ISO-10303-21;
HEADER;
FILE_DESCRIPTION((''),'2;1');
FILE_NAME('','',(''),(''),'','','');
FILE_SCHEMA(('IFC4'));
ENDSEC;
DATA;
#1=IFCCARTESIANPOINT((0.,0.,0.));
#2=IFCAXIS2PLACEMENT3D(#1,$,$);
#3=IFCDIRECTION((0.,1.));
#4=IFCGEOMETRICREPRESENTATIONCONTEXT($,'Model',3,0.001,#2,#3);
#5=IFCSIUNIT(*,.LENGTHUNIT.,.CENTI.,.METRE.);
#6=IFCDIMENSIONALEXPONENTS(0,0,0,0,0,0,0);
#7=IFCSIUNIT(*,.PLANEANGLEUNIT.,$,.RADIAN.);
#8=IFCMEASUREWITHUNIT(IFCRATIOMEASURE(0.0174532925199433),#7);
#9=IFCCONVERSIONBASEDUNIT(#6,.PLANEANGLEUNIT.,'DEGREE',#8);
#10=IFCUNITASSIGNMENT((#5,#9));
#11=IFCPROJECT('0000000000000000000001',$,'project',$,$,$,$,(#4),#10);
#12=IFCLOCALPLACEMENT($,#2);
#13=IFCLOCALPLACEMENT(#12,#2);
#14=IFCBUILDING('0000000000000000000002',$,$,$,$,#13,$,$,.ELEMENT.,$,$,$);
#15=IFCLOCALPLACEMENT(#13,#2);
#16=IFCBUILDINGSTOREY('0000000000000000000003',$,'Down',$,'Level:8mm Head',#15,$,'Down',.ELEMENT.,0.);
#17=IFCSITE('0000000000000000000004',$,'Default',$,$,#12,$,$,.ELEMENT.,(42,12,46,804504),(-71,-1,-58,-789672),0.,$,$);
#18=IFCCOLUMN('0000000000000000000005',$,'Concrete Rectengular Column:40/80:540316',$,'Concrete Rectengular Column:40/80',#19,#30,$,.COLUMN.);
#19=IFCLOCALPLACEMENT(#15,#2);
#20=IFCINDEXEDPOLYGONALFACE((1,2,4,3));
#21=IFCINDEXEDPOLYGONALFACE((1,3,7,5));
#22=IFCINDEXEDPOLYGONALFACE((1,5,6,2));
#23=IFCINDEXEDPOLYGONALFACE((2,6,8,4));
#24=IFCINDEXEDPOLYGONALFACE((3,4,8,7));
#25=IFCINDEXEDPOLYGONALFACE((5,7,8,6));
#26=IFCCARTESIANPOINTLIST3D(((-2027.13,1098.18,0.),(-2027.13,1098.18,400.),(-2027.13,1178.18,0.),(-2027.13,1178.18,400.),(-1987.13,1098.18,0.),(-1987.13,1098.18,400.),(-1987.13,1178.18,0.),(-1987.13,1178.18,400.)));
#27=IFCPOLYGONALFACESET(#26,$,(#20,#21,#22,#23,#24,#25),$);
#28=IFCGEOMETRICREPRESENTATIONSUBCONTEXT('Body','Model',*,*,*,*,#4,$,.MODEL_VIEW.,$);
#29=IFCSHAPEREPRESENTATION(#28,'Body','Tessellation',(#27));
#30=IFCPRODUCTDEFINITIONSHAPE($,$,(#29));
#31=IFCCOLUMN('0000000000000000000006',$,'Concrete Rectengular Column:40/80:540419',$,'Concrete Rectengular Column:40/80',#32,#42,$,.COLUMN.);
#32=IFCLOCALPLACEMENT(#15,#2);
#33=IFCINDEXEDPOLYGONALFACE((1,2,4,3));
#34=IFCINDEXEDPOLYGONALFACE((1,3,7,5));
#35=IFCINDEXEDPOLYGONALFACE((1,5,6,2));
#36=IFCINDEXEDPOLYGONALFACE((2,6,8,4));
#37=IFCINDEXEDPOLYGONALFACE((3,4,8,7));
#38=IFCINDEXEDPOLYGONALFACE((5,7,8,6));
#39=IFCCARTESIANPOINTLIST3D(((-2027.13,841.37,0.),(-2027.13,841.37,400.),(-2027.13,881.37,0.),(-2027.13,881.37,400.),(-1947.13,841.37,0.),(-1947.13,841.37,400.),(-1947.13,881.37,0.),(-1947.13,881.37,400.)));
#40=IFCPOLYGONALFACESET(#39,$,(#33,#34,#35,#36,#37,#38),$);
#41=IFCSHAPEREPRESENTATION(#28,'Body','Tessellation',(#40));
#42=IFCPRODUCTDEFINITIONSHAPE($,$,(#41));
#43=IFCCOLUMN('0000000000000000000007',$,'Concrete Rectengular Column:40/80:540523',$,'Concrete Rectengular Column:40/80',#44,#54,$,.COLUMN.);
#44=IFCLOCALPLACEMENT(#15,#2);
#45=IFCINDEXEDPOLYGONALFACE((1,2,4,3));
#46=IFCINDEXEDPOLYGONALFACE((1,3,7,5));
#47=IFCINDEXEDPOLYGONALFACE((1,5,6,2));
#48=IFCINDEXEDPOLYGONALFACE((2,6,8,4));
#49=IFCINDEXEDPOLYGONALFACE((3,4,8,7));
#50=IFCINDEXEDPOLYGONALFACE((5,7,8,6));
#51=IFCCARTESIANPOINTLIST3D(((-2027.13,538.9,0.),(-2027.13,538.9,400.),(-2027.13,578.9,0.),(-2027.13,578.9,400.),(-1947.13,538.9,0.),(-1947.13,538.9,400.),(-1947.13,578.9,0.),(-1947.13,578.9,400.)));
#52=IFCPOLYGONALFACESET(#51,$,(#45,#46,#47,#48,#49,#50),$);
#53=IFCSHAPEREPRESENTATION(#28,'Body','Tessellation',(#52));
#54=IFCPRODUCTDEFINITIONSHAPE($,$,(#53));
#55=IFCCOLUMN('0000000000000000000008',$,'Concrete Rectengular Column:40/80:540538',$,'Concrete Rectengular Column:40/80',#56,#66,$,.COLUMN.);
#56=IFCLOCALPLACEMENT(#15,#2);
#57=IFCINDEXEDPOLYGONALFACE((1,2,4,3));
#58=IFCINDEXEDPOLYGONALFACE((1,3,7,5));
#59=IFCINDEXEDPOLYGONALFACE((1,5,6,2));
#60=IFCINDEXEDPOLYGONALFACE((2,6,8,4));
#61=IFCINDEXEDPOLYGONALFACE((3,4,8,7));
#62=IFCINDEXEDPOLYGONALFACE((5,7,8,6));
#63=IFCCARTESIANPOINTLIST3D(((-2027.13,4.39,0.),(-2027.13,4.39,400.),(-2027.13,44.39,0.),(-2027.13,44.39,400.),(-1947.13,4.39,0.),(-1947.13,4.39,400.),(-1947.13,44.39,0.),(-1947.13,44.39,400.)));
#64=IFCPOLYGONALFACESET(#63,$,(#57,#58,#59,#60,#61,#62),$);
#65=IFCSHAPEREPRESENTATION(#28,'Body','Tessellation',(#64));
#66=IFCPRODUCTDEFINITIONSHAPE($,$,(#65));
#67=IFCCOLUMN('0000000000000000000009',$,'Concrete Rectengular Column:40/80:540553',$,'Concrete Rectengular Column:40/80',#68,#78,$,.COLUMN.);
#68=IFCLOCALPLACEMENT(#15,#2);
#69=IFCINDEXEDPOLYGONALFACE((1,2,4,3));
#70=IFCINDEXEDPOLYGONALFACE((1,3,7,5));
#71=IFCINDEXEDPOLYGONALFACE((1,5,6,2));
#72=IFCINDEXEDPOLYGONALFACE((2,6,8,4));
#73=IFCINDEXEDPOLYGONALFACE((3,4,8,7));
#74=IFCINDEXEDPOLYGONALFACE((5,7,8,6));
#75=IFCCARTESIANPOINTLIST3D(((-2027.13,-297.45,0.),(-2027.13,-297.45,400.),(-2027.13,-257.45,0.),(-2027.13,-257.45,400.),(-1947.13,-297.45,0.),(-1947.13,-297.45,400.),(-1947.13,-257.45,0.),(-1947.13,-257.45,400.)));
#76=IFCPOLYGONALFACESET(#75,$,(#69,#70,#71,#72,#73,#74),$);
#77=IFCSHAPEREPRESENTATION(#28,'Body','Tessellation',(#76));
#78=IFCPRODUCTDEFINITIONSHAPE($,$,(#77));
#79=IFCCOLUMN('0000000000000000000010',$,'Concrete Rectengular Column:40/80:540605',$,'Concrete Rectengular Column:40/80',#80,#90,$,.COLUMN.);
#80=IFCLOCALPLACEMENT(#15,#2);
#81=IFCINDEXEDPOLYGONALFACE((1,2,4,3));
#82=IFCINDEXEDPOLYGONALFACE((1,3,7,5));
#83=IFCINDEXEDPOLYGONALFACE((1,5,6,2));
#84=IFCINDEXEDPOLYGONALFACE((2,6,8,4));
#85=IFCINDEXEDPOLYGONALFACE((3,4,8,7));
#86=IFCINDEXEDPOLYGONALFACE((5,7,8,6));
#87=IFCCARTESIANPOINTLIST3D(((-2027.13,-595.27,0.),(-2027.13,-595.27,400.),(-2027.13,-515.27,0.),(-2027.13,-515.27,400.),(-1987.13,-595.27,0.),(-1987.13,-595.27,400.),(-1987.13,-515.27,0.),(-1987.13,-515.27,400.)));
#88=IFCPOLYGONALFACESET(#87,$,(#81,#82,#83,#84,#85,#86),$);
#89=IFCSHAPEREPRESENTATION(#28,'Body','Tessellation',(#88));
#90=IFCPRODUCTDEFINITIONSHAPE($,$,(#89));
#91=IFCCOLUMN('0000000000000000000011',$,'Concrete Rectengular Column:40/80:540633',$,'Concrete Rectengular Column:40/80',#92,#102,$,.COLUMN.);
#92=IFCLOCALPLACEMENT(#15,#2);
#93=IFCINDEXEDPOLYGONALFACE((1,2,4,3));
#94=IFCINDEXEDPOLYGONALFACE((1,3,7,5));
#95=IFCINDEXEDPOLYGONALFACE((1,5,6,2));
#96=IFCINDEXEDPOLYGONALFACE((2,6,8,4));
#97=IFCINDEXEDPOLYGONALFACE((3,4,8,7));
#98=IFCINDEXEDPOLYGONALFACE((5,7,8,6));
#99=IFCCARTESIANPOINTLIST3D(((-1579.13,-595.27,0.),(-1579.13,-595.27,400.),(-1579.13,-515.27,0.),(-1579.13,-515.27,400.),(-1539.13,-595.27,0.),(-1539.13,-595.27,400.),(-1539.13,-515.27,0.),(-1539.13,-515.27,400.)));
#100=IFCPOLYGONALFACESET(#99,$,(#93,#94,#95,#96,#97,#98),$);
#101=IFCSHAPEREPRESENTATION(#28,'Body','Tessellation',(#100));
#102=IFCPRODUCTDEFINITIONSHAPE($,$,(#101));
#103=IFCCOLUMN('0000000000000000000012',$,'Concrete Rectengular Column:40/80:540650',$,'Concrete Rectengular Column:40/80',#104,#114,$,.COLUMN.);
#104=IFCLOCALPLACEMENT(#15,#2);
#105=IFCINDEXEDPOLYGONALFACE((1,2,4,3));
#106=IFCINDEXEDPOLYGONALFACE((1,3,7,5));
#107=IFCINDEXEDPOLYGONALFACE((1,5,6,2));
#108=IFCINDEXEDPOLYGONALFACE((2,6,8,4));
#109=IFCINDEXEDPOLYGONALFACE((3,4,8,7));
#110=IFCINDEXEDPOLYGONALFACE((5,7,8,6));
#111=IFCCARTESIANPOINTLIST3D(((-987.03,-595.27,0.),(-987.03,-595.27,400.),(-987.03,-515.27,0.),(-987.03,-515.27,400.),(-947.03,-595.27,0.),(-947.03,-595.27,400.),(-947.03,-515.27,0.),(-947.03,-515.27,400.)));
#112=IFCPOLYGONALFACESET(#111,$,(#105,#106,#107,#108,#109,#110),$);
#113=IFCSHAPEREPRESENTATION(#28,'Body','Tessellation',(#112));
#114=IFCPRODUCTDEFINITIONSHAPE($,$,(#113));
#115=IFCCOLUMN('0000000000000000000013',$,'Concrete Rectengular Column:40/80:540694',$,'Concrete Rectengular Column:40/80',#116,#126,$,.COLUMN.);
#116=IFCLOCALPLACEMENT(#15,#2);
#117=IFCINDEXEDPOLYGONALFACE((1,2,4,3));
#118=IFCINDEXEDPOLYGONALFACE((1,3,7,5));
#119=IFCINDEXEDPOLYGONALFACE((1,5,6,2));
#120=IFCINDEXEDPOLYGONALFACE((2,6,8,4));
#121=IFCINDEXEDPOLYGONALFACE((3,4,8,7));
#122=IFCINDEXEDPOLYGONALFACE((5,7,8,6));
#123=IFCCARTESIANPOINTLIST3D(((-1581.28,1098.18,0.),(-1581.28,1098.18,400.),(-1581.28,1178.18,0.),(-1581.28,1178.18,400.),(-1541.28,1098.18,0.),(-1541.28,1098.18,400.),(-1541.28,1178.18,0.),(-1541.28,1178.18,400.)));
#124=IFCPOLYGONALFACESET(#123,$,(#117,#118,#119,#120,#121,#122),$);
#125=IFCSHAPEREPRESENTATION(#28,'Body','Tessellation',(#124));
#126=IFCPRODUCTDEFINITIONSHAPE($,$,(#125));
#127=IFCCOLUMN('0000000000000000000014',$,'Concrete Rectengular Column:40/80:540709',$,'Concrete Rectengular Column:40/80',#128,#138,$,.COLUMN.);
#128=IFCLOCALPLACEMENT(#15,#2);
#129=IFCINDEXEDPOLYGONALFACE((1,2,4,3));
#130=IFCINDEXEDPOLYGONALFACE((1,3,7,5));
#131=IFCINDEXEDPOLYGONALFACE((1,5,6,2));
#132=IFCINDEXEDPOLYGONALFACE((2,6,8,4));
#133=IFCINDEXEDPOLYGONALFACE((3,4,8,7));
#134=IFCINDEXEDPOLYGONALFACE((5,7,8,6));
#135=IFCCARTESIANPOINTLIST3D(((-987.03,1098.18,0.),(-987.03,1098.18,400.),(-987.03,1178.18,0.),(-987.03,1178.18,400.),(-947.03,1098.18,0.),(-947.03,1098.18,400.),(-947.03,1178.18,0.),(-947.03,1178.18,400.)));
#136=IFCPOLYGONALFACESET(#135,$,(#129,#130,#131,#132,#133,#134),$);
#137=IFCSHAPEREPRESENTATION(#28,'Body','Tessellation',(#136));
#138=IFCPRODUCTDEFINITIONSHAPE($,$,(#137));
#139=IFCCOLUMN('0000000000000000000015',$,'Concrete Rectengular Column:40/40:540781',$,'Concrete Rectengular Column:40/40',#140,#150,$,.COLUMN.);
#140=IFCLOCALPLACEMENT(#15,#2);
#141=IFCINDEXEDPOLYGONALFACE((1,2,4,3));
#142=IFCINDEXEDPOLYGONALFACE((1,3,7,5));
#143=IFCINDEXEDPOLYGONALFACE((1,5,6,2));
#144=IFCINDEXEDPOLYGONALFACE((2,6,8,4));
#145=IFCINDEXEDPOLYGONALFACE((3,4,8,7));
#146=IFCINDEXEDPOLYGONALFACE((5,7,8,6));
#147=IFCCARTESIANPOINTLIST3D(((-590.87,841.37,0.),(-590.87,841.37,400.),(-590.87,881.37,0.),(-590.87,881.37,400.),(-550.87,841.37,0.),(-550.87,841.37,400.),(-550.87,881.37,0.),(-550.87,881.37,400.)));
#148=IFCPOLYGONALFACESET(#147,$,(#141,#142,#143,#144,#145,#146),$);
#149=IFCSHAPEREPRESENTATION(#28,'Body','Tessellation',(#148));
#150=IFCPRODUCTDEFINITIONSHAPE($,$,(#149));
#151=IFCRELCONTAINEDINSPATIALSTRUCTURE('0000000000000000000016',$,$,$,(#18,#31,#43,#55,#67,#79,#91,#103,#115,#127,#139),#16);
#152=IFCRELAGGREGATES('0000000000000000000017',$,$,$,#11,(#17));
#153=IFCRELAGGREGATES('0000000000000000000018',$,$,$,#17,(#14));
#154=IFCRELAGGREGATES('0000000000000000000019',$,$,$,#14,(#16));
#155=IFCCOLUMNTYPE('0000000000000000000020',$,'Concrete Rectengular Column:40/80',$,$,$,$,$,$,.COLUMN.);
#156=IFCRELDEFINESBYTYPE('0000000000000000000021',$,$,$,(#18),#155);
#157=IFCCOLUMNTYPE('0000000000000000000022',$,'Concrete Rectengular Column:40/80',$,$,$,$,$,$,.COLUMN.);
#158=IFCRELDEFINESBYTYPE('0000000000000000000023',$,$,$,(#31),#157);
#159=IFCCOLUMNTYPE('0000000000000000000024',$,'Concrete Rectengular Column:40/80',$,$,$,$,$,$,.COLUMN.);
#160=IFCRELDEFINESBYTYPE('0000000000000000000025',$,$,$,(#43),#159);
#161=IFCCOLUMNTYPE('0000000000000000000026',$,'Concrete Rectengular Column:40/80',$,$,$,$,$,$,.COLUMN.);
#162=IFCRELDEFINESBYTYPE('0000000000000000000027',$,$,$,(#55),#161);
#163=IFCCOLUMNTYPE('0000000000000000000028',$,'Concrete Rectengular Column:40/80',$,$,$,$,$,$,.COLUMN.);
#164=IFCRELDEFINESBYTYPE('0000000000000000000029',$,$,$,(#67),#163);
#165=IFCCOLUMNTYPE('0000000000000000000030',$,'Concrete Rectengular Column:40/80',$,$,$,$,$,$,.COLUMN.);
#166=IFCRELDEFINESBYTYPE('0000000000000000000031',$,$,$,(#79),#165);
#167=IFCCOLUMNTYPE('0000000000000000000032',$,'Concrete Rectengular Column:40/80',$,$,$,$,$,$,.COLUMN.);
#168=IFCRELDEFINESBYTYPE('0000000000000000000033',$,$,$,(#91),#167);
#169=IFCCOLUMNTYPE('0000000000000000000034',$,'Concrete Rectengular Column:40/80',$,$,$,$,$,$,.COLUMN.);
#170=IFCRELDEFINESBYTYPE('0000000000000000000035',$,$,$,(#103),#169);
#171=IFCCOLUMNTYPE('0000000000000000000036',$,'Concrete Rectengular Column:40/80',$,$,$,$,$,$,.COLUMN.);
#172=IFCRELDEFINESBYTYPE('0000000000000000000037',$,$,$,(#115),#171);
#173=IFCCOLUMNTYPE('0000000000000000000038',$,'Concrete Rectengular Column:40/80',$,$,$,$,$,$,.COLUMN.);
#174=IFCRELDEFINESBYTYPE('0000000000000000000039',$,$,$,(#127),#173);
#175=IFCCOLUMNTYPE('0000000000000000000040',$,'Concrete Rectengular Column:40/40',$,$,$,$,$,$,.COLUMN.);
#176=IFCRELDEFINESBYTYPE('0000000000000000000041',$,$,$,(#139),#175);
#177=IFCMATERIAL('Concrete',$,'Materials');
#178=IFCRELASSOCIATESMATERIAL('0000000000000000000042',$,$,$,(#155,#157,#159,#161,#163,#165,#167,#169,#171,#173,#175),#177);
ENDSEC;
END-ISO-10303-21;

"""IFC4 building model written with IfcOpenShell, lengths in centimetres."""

from ifc_helpers import new_model, entity, si_unit, converted_unit, direction, frame, origin, place, context, subcontext, project, spatial, indexed_curve, outline, extrude, source, transform, mapped, material, type_object, type_shapes, element, save


model = new_model("IFC4")

# Units and contexts
model_context = context("Model", 3, precision=0.001, world=origin(), true_north=direction((0.0, 1.0)))
body_context = subcontext(model_context, "Body", "Model", "MODEL_VIEW")
ifc_project = project(units=[si_unit("LENGTHUNIT", "METRE", prefix="CENTI"), converted_unit("PLANEANGLEUNIT", "DEGREE", entity("IfcRatioMeasure", 0.0174532925199433), si_unit("PLANEANGLEUNIT", "RADIAN"), dimensions=[0, 0, 0, 0, 0, 0, 0])], contexts=[model_context])

# Site, building, storey
site_placement = place(None, origin())
site = spatial("IfcSite", under=ifc_project, at=site_placement, Name="Default", CompositionType="ELEMENT", RefLatitude=(42, 12, 46, 804504), RefLongitude=(-71, -1, -58, -789672), RefElevation=0.0)
building_placement = place(site_placement, origin())
building = spatial("IfcBuilding", under=site, at=building_placement, CompositionType="ELEMENT")
storey_placement = place(building_placement, origin())
storey = spatial("IfcBuildingStorey", under=building, at=storey_placement, Name="Down", ObjectType="Level:8mm Head", LongName="Down", CompositionType="ELEMENT", Elevation=0.0)

# Columns
ifc_material = material(Name="Concrete", Category="Materials")
column_type_1 = type_object("IfcColumnType", Name="Concrete Rectengular Column:40/80", PredefinedType="COLUMN", material=ifc_material)
shared_shape_1 = source(origin(), body_context, "Body", "SweptSolid", [
    extrude(outline(indexed_curve([(-40.0, -20.0), (40.0, -20.0), (40.0, 20.0), (-40.0, 20.0), (-40.0, -20.0)], self_intersect=False)), frame((-2007.13, 1138.18, 0.0), z_axis=(0.0, 0.0, 1.0), x_axis=(0.0, -1.0, 0.0)), (0.0, 0.0, 1.0), 400.0),
])
type_shapes(column_type_1, [shared_shape_1])
column_1_placement = place(storey_placement, origin())
element("IfcColumn", 1, at=column_1_placement, inside=storey, type_object=column_type_1, Name="Concrete Rectengular Column:40/80:540316", ObjectType="Concrete Rectengular Column:40/80", PredefinedType="COLUMN", context=body_context, shape_type="MappedRepresentation", body=[
    mapped(shared_shape_1, transform((0.0, 0.0, 0.0), scale=1.0)),
])
column_type_2 = type_object("IfcColumnType", Name="Concrete Rectengular Column:40/80", PredefinedType="COLUMN", material=ifc_material)
shared_shape_2 = source(origin(), body_context, "Body", "SweptSolid", [
    extrude(outline(indexed_curve([(-20.0, -40.0), (20.0, -40.0), (20.0, 40.0), (-20.0, 40.0), (-20.0, -40.0)], self_intersect=False)), frame((-1987.13, 861.37, 0.0), z_axis=(0.0, 0.0, 1.0), x_axis=(0.0, -1.0, 0.0)), (0.0, 0.0, 1.0), 400.0),
])
type_shapes(column_type_2, [shared_shape_2])
column_2_placement = place(storey_placement, origin())
element("IfcColumn", 2, at=column_2_placement, inside=storey, type_object=column_type_2, Name="Concrete Rectengular Column:40/80:540419", ObjectType="Concrete Rectengular Column:40/80", PredefinedType="COLUMN", context=body_context, shape_type="MappedRepresentation", body=[
    mapped(shared_shape_2, transform((0.0, 0.0, 0.0), scale=1.0)),
])
column_type_3 = type_object("IfcColumnType", Name="Concrete Rectengular Column:40/80", PredefinedType="COLUMN", material=ifc_material)
shared_shape_3 = source(origin(), body_context, "Body", "SweptSolid", [
    extrude(outline(indexed_curve([(-20.0, -40.0), (20.0, -40.0), (20.0, 40.0), (-20.0, 40.0), (-20.0, -40.0)], self_intersect=False)), frame((-1987.13, 558.9, 0.0), z_axis=(0.0, 0.0, 1.0), x_axis=(0.0, -1.0, 0.0)), (0.0, 0.0, 1.0), 400.0),
])
type_shapes(column_type_3, [shared_shape_3])
column_3_placement = place(storey_placement, origin())
element("IfcColumn", 3, at=column_3_placement, inside=storey, type_object=column_type_3, Name="Concrete Rectengular Column:40/80:540523", ObjectType="Concrete Rectengular Column:40/80", PredefinedType="COLUMN", context=body_context, shape_type="MappedRepresentation", body=[
    mapped(shared_shape_3, transform((0.0, 0.0, 0.0), scale=1.0)),
])
column_type_4 = type_object("IfcColumnType", Name="Concrete Rectengular Column:40/80", PredefinedType="COLUMN", material=ifc_material)
shared_shape_4 = source(origin(), body_context, "Body", "SweptSolid", [
    extrude(outline(indexed_curve([(-20.0, -40.0), (20.0, -40.0), (20.0, 40.0), (-20.0, 40.0), (-20.0, -40.0)], self_intersect=False)), frame((-1987.13, 24.39, 0.0), z_axis=(0.0, 0.0, 1.0), x_axis=(0.0, -1.0, 0.0)), (0.0, 0.0, 1.0), 400.0),
])
type_shapes(column_type_4, [shared_shape_4])
column_4_placement = place(storey_placement, origin())
element("IfcColumn", 4, at=column_4_placement, inside=storey, type_object=column_type_4, Name="Concrete Rectengular Column:40/80:540538", ObjectType="Concrete Rectengular Column:40/80", PredefinedType="COLUMN", context=body_context, shape_type="MappedRepresentation", body=[
    mapped(shared_shape_4, transform((0.0, 0.0, 0.0), scale=1.0)),
])
column_type_5 = type_object("IfcColumnType", Name="Concrete Rectengular Column:40/80", PredefinedType="COLUMN", material=ifc_material)
shared_shape_5 = source(origin(), body_context, "Body", "SweptSolid", [
    extrude(outline(indexed_curve([(-20.0, -40.0), (20.0, -40.0), (20.0, 40.0), (-20.0, 40.0), (-20.0, -40.0)], self_intersect=False)), frame((-1987.13, -277.45, 0.0), z_axis=(0.0, 0.0, 1.0), x_axis=(0.0, -1.0, 0.0)), (0.0, 0.0, 1.0), 400.0),
])
type_shapes(column_type_5, [shared_shape_5])
column_5_placement = place(storey_placement, origin())
element("IfcColumn", 5, at=column_5_placement, inside=storey, type_object=column_type_5, Name="Concrete Rectengular Column:40/80:540553", ObjectType="Concrete Rectengular Column:40/80", PredefinedType="COLUMN", context=body_context, shape_type="MappedRepresentation", body=[
    mapped(shared_shape_5, transform((0.0, 0.0, 0.0), scale=1.0)),
])
column_type_6 = type_object("IfcColumnType", Name="Concrete Rectengular Column:40/80", PredefinedType="COLUMN", material=ifc_material)
shared_shape_6 = source(origin(), body_context, "Body", "SweptSolid", [
    extrude(outline(indexed_curve([(-40.0, -20.0), (40.0, -20.0), (40.0, 20.0), (-40.0, 20.0), (-40.0, -20.0)], self_intersect=False)), frame((-2007.13, -555.27, 0.0), z_axis=(0.0, 0.0, 1.0), x_axis=(0.0, -1.0, 0.0)), (0.0, 0.0, 1.0), 400.0),
])
type_shapes(column_type_6, [shared_shape_6])
column_6_placement = place(storey_placement, origin())
element("IfcColumn", 6, at=column_6_placement, inside=storey, type_object=column_type_6, Name="Concrete Rectengular Column:40/80:540605", ObjectType="Concrete Rectengular Column:40/80", PredefinedType="COLUMN", context=body_context, shape_type="MappedRepresentation", body=[
    mapped(shared_shape_6, transform((0.0, 0.0, 0.0), scale=1.0)),
])
column_type_7 = type_object("IfcColumnType", Name="Concrete Rectengular Column:40/80", PredefinedType="COLUMN", material=ifc_material)
shared_shape_7 = source(origin(), body_context, "Body", "SweptSolid", [
    extrude(outline(indexed_curve([(-40.0, -20.0), (40.0, -20.0), (40.0, 20.0), (-40.0, 20.0), (-40.0, -20.0)], self_intersect=False)), frame((-1559.13, -555.27, 0.0), z_axis=(0.0, 0.0, 1.0), x_axis=(0.0, -1.0, 0.0)), (0.0, 0.0, 1.0), 400.0),
])
type_shapes(column_type_7, [shared_shape_7])
column_7_placement = place(storey_placement, origin())
element("IfcColumn", 7, at=column_7_placement, inside=storey, type_object=column_type_7, Name="Concrete Rectengular Column:40/80:540633", ObjectType="Concrete Rectengular Column:40/80", PredefinedType="COLUMN", context=body_context, shape_type="MappedRepresentation", body=[
    mapped(shared_shape_7, transform((0.0, 0.0, 0.0), scale=1.0)),
])
column_type_8 = type_object("IfcColumnType", Name="Concrete Rectengular Column:40/80", PredefinedType="COLUMN", material=ifc_material)
shared_shape_8 = source(origin(), body_context, "Body", "SweptSolid", [
    extrude(outline(indexed_curve([(-40.0, -20.0), (40.0, -20.0), (40.0, 20.0), (-40.0, 20.0), (-40.0, -20.0)], self_intersect=False)), frame((-967.03, -555.27, 0.0), z_axis=(0.0, 0.0, 1.0), x_axis=(0.0, -1.0, 0.0)), (0.0, 0.0, 1.0), 400.0),
])
type_shapes(column_type_8, [shared_shape_8])
column_8_placement = place(storey_placement, origin())
element("IfcColumn", 8, at=column_8_placement, inside=storey, type_object=column_type_8, Name="Concrete Rectengular Column:40/80:540650", ObjectType="Concrete Rectengular Column:40/80", PredefinedType="COLUMN", context=body_context, shape_type="MappedRepresentation", body=[
    mapped(shared_shape_8, transform((0.0, 0.0, 0.0), scale=1.0)),
])
column_type_9 = type_object("IfcColumnType", Name="Concrete Rectengular Column:40/80", PredefinedType="COLUMN", material=ifc_material)
shared_shape_9 = source(origin(), body_context, "Body", "SweptSolid", [
    extrude(outline(indexed_curve([(-40.0, -20.0), (40.0, -20.0), (40.0, 20.0), (-40.0, 20.0), (-40.0, -20.0)], self_intersect=False)), frame((-1561.28, 1138.18, 0.0), z_axis=(0.0, 0.0, 1.0), x_axis=(0.0, -1.0, 0.0)), (0.0, 0.0, 1.0), 400.0),
])
type_shapes(column_type_9, [shared_shape_9])
column_9_placement = place(storey_placement, origin())
element("IfcColumn", 9, at=column_9_placement, inside=storey, type_object=column_type_9, Name="Concrete Rectengular Column:40/80:540694", ObjectType="Concrete Rectengular Column:40/80", PredefinedType="COLUMN", context=body_context, shape_type="MappedRepresentation", body=[
    mapped(shared_shape_9, transform((0.0, 0.0, 0.0), scale=1.0)),
])
column_type_10 = type_object("IfcColumnType", Name="Concrete Rectengular Column:40/80", PredefinedType="COLUMN", material=ifc_material)
shared_shape_10 = source(origin(), body_context, "Body", "SweptSolid", [
    extrude(outline(indexed_curve([(-40.0, -20.0), (40.0, -20.0), (40.0, 20.0), (-40.0, 20.0), (-40.0, -20.0)], self_intersect=False)), frame((-967.03, 1138.18, 0.0), z_axis=(0.0, 0.0, 1.0), x_axis=(0.0, -1.0, 0.0)), (0.0, 0.0, 1.0), 400.0),
])
type_shapes(column_type_10, [shared_shape_10])
column_10_placement = place(storey_placement, origin())
element("IfcColumn", 10, at=column_10_placement, inside=storey, type_object=column_type_10, Name="Concrete Rectengular Column:40/80:540709", ObjectType="Concrete Rectengular Column:40/80", PredefinedType="COLUMN", context=body_context, shape_type="MappedRepresentation", body=[
    mapped(shared_shape_10, transform((0.0, 0.0, 0.0), scale=1.0)),
])
column_type_11 = type_object("IfcColumnType", Name="Concrete Rectengular Column:40/40", PredefinedType="COLUMN", material=ifc_material)
shared_shape_11 = source(origin(), body_context, "Body", "SweptSolid", [
    extrude(outline(indexed_curve([(-20.0, -20.0), (20.0, -20.0), (20.0, 20.0), (-20.0, 20.0), (-20.0, -20.0)], self_intersect=False)), frame((-570.87, 861.37, 0.0), z_axis=(0.0, 0.0, 1.0), x_axis=(0.0, -1.0, 0.0)), (0.0, 0.0, 1.0), 400.0),
])
type_shapes(column_type_11, [shared_shape_11])
column_11_placement = place(storey_placement, origin())
element("IfcColumn", 11, at=column_11_placement, inside=storey, type_object=column_type_11, Name="Concrete Rectengular Column:40/40:540781", ObjectType="Concrete Rectengular Column:40/40", PredefinedType="COLUMN", context=body_context, shape_type="MappedRepresentation", body=[
    mapped(shared_shape_11, transform((0.0, 0.0, 0.0), scale=1.0)),
])

save(model, "model.ifc")
